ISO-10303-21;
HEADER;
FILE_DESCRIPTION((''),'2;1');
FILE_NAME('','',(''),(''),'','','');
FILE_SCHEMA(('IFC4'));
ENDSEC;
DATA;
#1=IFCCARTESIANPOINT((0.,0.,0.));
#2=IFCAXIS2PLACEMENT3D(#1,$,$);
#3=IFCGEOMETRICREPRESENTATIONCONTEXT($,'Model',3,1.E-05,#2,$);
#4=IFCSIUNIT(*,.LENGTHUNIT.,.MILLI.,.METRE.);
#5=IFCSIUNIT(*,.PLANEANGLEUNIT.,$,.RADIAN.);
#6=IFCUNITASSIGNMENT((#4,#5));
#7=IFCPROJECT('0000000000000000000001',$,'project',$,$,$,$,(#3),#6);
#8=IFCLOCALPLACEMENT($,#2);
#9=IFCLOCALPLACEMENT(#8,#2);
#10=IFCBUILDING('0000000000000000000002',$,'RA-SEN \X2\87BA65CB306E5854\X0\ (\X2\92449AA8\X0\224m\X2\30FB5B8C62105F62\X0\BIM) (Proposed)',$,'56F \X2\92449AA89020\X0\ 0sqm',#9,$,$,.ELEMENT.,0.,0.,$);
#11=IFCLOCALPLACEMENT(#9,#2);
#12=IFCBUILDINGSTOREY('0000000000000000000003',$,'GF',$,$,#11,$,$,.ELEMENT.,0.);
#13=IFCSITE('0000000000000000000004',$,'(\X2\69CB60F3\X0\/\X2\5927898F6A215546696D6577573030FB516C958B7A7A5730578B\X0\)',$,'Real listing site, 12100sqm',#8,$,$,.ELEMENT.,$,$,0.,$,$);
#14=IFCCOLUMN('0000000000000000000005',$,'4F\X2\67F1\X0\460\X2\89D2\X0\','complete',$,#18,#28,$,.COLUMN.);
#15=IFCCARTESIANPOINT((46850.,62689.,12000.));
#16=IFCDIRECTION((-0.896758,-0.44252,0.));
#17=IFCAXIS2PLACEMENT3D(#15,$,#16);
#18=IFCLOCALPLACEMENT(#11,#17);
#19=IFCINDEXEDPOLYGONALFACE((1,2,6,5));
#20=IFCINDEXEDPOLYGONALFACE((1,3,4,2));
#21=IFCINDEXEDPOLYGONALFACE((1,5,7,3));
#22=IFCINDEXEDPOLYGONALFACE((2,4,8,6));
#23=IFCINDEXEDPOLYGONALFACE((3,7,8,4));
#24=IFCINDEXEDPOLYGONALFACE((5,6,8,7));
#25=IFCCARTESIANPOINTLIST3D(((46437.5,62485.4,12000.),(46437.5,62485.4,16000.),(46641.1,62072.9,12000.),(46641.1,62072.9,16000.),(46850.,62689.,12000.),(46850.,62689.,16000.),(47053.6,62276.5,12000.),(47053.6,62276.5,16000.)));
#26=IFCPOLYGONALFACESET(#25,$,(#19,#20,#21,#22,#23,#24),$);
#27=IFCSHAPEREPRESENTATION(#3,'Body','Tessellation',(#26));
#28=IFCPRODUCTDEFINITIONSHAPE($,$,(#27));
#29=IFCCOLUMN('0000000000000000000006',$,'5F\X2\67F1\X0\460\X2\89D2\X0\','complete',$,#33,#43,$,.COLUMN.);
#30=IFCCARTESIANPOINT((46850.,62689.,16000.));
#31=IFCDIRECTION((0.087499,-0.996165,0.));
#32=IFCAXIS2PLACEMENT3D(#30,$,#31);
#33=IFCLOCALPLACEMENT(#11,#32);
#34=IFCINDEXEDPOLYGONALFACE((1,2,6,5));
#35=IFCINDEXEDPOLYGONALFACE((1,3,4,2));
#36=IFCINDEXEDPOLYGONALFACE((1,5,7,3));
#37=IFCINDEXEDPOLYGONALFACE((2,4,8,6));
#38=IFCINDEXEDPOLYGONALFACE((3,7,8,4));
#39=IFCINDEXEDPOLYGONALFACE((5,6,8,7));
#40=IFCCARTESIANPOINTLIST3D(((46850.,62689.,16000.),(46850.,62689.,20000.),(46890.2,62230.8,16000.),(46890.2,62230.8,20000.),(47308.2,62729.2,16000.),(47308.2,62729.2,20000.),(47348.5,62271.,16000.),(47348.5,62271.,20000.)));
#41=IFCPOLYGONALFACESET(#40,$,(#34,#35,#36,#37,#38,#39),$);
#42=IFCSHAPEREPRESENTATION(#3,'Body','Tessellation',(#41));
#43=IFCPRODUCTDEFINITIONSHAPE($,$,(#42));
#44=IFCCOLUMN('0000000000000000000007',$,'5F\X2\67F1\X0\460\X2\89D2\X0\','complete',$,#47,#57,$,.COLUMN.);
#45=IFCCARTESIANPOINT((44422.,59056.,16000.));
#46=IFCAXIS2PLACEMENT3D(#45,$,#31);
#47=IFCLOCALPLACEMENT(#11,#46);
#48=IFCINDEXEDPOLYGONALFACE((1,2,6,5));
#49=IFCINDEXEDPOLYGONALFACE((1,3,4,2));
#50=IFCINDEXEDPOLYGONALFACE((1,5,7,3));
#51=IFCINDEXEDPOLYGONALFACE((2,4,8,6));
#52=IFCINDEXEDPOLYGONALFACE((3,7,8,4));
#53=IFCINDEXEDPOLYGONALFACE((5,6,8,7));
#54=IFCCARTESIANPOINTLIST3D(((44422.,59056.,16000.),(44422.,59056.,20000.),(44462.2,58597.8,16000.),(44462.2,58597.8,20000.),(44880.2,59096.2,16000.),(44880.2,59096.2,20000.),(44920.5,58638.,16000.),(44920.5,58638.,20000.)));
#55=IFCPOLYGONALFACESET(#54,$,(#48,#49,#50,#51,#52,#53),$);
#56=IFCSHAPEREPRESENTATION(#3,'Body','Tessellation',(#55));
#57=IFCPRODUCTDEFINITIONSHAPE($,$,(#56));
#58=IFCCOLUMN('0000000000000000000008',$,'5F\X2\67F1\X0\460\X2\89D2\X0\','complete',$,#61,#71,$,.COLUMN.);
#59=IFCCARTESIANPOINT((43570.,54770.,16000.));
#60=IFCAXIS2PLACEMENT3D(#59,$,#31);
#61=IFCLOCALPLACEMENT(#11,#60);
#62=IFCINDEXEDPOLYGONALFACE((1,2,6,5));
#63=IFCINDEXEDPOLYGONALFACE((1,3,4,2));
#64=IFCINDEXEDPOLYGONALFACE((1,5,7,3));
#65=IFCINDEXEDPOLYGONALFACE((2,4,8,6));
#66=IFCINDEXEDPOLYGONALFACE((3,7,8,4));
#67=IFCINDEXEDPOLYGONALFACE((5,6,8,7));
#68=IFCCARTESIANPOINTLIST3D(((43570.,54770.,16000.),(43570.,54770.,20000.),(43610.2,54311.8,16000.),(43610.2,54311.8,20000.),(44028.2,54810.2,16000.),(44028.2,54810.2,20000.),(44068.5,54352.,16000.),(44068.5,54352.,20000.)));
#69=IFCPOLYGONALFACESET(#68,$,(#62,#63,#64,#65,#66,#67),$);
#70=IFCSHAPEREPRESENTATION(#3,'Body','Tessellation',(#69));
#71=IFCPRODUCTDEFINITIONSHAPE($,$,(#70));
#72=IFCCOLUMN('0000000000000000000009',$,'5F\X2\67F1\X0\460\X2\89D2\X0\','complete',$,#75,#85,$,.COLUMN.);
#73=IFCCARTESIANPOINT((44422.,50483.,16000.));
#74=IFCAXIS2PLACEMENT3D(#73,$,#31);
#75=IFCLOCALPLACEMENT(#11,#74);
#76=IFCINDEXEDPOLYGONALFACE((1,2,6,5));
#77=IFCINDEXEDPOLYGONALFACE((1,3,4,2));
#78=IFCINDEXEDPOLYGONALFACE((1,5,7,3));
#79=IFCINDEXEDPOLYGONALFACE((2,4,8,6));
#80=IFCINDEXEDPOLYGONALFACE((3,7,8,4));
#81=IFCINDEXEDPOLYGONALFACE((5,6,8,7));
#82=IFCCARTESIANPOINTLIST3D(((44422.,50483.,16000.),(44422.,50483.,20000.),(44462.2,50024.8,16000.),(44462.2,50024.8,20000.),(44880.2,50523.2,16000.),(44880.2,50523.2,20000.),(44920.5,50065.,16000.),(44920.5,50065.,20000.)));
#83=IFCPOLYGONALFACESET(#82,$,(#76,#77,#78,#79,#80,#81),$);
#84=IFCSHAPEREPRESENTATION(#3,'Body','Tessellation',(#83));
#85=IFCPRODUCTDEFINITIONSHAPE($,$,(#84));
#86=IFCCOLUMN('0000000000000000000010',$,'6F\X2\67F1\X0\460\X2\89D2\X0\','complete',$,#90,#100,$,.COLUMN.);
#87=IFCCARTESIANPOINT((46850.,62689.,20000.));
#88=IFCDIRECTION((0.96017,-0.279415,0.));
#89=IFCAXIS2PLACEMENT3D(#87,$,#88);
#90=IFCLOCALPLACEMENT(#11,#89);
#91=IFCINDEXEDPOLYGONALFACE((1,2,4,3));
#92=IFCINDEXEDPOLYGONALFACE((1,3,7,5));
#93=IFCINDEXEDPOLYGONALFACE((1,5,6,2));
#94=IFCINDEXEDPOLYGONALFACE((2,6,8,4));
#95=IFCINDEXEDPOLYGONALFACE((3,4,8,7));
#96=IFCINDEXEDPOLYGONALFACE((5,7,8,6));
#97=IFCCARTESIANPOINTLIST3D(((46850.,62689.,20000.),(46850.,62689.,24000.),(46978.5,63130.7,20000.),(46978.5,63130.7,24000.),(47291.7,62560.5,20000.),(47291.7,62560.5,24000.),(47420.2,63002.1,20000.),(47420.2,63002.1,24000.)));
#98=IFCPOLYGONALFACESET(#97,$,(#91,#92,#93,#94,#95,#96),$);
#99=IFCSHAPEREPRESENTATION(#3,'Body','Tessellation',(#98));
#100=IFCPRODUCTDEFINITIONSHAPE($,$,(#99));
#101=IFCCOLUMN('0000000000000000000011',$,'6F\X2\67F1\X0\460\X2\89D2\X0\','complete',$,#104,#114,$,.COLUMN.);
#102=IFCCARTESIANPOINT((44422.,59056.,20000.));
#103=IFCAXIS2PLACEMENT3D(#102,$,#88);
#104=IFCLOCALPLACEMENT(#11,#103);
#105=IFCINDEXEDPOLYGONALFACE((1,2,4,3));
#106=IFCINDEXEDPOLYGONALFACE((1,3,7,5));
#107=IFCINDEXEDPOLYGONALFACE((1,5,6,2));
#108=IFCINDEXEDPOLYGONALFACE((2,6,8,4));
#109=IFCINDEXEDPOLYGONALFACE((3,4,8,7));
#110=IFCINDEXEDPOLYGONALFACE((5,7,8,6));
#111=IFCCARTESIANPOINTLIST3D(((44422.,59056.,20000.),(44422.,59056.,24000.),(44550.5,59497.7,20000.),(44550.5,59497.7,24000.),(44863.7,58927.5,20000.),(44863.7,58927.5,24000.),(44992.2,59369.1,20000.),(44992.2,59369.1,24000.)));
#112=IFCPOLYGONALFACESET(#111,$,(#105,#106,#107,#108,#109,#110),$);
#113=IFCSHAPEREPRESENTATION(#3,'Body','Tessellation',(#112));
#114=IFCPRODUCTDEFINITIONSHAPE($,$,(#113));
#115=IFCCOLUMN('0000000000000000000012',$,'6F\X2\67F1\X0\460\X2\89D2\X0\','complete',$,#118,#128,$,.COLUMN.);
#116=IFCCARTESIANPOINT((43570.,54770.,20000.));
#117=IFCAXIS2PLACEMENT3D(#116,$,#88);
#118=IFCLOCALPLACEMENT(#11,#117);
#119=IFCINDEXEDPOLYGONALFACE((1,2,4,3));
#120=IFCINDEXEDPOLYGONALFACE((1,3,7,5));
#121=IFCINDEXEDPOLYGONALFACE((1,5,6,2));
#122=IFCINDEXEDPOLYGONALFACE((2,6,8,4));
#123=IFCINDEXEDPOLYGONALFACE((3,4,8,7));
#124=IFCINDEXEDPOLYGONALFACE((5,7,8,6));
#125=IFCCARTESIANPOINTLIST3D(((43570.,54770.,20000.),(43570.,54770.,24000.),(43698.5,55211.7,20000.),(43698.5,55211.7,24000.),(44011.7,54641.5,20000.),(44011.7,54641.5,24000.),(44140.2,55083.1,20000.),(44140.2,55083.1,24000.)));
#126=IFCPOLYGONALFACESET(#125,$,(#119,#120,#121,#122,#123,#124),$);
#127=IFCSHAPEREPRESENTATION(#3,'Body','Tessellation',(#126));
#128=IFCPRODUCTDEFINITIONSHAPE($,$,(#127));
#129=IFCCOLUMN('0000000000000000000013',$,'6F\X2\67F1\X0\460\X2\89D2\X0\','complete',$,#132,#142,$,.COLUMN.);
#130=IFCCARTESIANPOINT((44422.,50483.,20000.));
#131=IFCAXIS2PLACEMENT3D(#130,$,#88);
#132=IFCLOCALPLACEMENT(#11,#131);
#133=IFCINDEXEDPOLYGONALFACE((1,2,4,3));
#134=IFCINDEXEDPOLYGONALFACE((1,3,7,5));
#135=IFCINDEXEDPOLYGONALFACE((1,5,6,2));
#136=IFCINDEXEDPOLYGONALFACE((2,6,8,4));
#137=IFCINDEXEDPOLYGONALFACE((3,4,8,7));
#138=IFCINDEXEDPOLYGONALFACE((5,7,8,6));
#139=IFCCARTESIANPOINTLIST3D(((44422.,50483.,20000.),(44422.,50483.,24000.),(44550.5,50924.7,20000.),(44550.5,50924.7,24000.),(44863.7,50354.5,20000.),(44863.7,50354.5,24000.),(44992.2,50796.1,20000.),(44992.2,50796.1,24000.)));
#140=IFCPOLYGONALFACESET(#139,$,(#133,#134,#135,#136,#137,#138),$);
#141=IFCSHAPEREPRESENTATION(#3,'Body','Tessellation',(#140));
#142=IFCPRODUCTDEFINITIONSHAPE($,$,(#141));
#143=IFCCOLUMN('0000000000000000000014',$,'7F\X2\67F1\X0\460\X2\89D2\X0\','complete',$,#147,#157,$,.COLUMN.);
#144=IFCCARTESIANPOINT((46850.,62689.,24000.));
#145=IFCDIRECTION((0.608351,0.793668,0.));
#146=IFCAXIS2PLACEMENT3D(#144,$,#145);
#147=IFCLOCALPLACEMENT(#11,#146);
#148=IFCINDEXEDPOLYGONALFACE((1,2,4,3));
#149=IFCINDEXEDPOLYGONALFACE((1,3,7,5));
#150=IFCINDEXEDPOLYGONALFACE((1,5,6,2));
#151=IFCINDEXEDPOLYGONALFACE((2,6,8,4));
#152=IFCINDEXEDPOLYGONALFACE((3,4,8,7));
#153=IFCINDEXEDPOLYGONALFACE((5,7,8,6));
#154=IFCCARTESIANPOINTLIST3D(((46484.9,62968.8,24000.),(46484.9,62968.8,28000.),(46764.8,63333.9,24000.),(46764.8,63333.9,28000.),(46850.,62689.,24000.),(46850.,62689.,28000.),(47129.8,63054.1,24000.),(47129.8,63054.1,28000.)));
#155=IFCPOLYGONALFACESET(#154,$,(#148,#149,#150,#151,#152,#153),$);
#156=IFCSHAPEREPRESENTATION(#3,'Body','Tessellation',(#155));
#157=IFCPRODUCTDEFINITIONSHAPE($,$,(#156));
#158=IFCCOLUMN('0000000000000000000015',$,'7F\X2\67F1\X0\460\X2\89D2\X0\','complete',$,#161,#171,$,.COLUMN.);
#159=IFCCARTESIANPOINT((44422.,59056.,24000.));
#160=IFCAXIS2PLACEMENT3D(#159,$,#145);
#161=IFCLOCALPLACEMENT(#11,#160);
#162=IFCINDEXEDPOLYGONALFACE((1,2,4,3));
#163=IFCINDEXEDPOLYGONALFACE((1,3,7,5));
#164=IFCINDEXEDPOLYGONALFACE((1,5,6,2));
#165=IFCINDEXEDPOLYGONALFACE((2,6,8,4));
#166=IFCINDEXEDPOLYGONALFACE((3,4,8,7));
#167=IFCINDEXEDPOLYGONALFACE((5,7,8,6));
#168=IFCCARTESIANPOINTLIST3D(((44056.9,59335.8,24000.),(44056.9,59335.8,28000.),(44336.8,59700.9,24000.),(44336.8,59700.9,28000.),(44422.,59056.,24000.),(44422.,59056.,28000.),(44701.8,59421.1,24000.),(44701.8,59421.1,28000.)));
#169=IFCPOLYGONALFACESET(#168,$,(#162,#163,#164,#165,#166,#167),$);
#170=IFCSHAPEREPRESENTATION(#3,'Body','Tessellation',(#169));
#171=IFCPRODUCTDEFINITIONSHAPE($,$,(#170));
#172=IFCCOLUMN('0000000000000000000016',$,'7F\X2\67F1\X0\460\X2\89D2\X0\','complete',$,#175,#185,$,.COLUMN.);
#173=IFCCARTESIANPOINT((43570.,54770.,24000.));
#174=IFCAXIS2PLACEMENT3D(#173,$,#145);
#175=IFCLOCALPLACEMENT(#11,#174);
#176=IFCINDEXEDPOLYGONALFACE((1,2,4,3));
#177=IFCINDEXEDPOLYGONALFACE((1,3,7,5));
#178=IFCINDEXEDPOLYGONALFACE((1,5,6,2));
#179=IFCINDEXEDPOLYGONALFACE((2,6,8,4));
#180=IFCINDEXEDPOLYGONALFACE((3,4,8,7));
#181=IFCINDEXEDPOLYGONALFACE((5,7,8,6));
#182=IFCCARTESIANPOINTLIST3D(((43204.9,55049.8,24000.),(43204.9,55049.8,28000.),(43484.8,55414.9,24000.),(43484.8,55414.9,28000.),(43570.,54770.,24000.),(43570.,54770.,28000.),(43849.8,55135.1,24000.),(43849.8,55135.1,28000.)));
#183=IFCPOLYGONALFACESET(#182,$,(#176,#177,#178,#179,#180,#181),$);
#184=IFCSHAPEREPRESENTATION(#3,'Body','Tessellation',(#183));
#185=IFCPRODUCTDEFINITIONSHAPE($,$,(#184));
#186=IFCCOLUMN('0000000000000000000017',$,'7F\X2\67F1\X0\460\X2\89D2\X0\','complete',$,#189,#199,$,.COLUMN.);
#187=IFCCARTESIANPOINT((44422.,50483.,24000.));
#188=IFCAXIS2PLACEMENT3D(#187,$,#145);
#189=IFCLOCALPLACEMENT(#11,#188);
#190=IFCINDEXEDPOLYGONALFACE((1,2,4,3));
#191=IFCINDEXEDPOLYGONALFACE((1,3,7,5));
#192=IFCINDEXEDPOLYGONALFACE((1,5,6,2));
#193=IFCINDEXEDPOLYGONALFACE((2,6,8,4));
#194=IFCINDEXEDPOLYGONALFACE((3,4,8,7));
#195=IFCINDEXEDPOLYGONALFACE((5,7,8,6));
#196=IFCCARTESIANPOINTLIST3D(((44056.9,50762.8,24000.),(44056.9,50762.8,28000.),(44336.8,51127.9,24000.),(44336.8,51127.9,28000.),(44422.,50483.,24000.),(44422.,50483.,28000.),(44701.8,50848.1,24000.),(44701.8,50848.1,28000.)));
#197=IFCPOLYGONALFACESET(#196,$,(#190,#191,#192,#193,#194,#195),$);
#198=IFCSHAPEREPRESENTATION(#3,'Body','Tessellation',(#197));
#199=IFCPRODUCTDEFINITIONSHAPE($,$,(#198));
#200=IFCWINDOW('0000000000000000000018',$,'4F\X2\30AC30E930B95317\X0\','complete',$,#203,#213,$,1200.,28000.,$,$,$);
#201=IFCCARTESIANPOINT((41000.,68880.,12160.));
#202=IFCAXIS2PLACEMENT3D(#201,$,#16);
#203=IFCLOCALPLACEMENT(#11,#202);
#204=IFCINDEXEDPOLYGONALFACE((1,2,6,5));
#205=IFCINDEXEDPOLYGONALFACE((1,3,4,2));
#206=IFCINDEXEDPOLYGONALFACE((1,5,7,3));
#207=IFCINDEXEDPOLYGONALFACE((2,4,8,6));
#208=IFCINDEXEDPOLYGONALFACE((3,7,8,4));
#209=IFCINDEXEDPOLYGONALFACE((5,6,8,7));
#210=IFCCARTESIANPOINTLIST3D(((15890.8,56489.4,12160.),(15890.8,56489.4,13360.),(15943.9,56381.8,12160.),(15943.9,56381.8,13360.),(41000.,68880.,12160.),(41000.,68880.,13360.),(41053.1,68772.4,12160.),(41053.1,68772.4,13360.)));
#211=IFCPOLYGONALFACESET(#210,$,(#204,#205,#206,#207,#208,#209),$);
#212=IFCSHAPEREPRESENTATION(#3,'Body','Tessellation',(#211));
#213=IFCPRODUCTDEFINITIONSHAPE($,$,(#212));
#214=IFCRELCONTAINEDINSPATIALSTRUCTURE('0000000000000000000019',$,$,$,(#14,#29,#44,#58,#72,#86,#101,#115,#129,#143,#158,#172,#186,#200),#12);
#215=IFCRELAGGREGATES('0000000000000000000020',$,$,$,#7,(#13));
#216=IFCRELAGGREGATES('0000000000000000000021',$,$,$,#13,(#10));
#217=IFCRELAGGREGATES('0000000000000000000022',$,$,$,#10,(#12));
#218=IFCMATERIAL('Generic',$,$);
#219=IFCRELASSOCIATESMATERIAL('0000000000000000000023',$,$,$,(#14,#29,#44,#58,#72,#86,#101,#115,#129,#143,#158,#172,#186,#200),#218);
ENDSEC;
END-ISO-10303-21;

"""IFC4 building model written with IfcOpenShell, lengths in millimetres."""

from ifc_helpers import new_model, si_unit, frame, frame_2d, origin, place, context, project, spatial, rectangle, extrude, material, element, save


model = new_model("IFC4")

# Units and contexts
model_context = context("Model", 3, precision=1e-05, world=origin())
ifc_project = project(units=[si_unit("LENGTHUNIT", "METRE", prefix="MILLI"), si_unit("PLANEANGLEUNIT", "RADIAN")], contexts=[model_context])

# Site, building, storey
site_placement = place(None, origin())
site = spatial("IfcSite", under=ifc_project, at=site_placement, Name="(構想/大規模商業敷地・公開空地型)", ObjectType="Real listing site, 12100sqm", CompositionType="ELEMENT", RefElevation=0.0)
building_placement = place(site_placement, origin())
building = spatial("IfcBuilding", under=site, at=building_placement, Name="RA-SEN 螺旋の塔 (鉄骨224m・完成形BIM) (Proposed)", ObjectType="56F 鉄骨造 0sqm", CompositionType="ELEMENT", ElevationOfRefHeight=0.0, ElevationOfTerrain=0.0)
storey_placement = place(building_placement, origin())
storey = spatial("IfcBuildingStorey", under=building, at=storey_placement, Name="GF", CompositionType="ELEMENT", Elevation=0.0)

# Columns
ifc_material = material(Name="Generic")
column_1_placement = place(storey_placement, frame((46850.0, 62689.0, 12000.0), x_axis=(-0.896758, -0.44252, 0.0)))
element("IfcColumn", 1, at=column_1_placement, inside=storey, material=ifc_material, Name="4F柱460角", Description="complete", PredefinedType="COLUMN", context=model_context, shape_type="SweptSolid", body=[
    extrude(rectangle(XDim=460.0, YDim=460.0, at=frame_2d((230.0, 230.0))), frame((46850.0, 62689.0, 12000.0), x_axis=(-0.896758, -0.44252, 0.0)), (0.0, 0.0, 1.0), 4000.0),
])
column_2_placement = place(storey_placement, frame((46850.0, 62689.0, 16000.0), x_axis=(0.087499, -0.996165, 0.0)))
element("IfcColumn", 2, at=column_2_placement, inside=storey, material=ifc_material, Name="5F柱460角", Description="complete", PredefinedType="COLUMN", context=model_context, shape_type="SweptSolid", body=[
    extrude(rectangle(XDim=460.0, YDim=460.0, at=frame_2d((230.0, 230.0))), frame((46850.0, 62689.0, 16000.0), x_axis=(0.087499, -0.996165, 0.0)), (0.0, 0.0, 1.0), 4000.0),
])
column_3_placement = place(storey_placement, frame((44422.0, 59056.0, 16000.0), x_axis=(0.087499, -0.996165, 0.0)))
element("IfcColumn", 3, at=column_3_placement, inside=storey, material=ifc_material, Name="5F柱460角", Description="complete", PredefinedType="COLUMN", context=model_context, shape_type="SweptSolid", body=[
    extrude(rectangle(XDim=460.0, YDim=460.0, at=frame_2d((230.0, 230.0))), frame((44422.0, 59056.0, 16000.0), x_axis=(0.087499, -0.996165, 0.0)), (0.0, 0.0, 1.0), 4000.0),
])
column_4_placement = place(storey_placement, frame((43570.0, 54770.0, 16000.0), x_axis=(0.087499, -0.996165, 0.0)))
element("IfcColumn", 4, at=column_4_placement, inside=storey, material=ifc_material, Name="5F柱460角", Description="complete", PredefinedType="COLUMN", context=model_context, shape_type="SweptSolid", body=[
    extrude(rectangle(XDim=460.0, YDim=460.0, at=frame_2d((230.0, 230.0))), frame((43570.0, 54770.0, 16000.0), x_axis=(0.087499, -0.996165, 0.0)), (0.0, 0.0, 1.0), 4000.0),
])
column_5_placement = place(storey_placement, frame((44422.0, 50483.0, 16000.0), x_axis=(0.087499, -0.996165, 0.0)))
element("IfcColumn", 5, at=column_5_placement, inside=storey, material=ifc_material, Name="5F柱460角", Description="complete", PredefinedType="COLUMN", context=model_context, shape_type="SweptSolid", body=[
    extrude(rectangle(XDim=460.0, YDim=460.0, at=frame_2d((230.0, 230.0))), frame((44422.0, 50483.0, 16000.0), x_axis=(0.087499, -0.996165, 0.0)), (0.0, 0.0, 1.0), 4000.0),
])
column_6_placement = place(storey_placement, frame((46850.0, 62689.0, 20000.0), x_axis=(0.96017, -0.279415, 0.0)))
element("IfcColumn", 6, at=column_6_placement, inside=storey, material=ifc_material, Name="6F柱460角", Description="complete", PredefinedType="COLUMN", context=model_context, shape_type="SweptSolid", body=[
    extrude(rectangle(XDim=460.0, YDim=460.0, at=frame_2d((230.0, 230.0))), frame((46850.0, 62689.0, 20000.0), x_axis=(0.96017, -0.279415, 0.0)), (0.0, 0.0, 1.0), 4000.0),
])
column_7_placement = place(storey_placement, frame((44422.0, 59056.0, 20000.0), x_axis=(0.96017, -0.279415, 0.0)))
element("IfcColumn", 7, at=column_7_placement, inside=storey, material=ifc_material, Name="6F柱460角", Description="complete", PredefinedType="COLUMN", context=model_context, shape_type="SweptSolid", body=[
    extrude(rectangle(XDim=460.0, YDim=460.0, at=frame_2d((230.0, 230.0))), frame((44422.0, 59056.0, 20000.0), x_axis=(0.96017, -0.279415, 0.0)), (0.0, 0.0, 1.0), 4000.0),
])
column_8_placement = place(storey_placement, frame((43570.0, 54770.0, 20000.0), x_axis=(0.96017, -0.279415, 0.0)))
element("IfcColumn", 8, at=column_8_placement, inside=storey, material=ifc_material, Name="6F柱460角", Description="complete", PredefinedType="COLUMN", context=model_context, shape_type="SweptSolid", body=[
    extrude(rectangle(XDim=460.0, YDim=460.0, at=frame_2d((230.0, 230.0))), frame((43570.0, 54770.0, 20000.0), x_axis=(0.96017, -0.279415, 0.0)), (0.0, 0.0, 1.0), 4000.0),
])
column_9_placement = place(storey_placement, frame((44422.0, 50483.0, 20000.0), x_axis=(0.96017, -0.279415, 0.0)))
element("IfcColumn", 9, at=column_9_placement, inside=storey, material=ifc_material, Name="6F柱460角", Description="complete", PredefinedType="COLUMN", context=model_context, shape_type="SweptSolid", body=[
    extrude(rectangle(XDim=460.0, YDim=460.0, at=frame_2d((230.0, 230.0))), frame((44422.0, 50483.0, 20000.0), x_axis=(0.96017, -0.279415, 0.0)), (0.0, 0.0, 1.0), 4000.0),
])
column_10_placement = place(storey_placement, frame((46850.0, 62689.0, 24000.0), x_axis=(0.608351, 0.793668, 0.0)))
element("IfcColumn", 10, at=column_10_placement, inside=storey, material=ifc_material, Name="7F柱460角", Description="complete", PredefinedType="COLUMN", context=model_context, shape_type="SweptSolid", body=[
    extrude(rectangle(XDim=460.0, YDim=460.0, at=frame_2d((230.0, 230.0))), frame((46850.0, 62689.0, 24000.0), x_axis=(0.608351, 0.793668, 0.0)), (0.0, 0.0, 1.0), 4000.0),
])
column_11_placement = place(storey_placement, frame((44422.0, 59056.0, 24000.0), x_axis=(0.608351, 0.793668, 0.0)))
element("IfcColumn", 11, at=column_11_placement, inside=storey, material=ifc_material, Name="7F柱460角", Description="complete", PredefinedType="COLUMN", context=model_context, shape_type="SweptSolid", body=[
    extrude(rectangle(XDim=460.0, YDim=460.0, at=frame_2d((230.0, 230.0))), frame((44422.0, 59056.0, 24000.0), x_axis=(0.608351, 0.793668, 0.0)), (0.0, 0.0, 1.0), 4000.0),
])
column_12_placement = place(storey_placement, frame((43570.0, 54770.0, 24000.0), x_axis=(0.608351, 0.793668, 0.0)))
element("IfcColumn", 12, at=column_12_placement, inside=storey, material=ifc_material, Name="7F柱460角", Description="complete", PredefinedType="COLUMN", context=model_context, shape_type="SweptSolid", body=[
    extrude(rectangle(XDim=460.0, YDim=460.0, at=frame_2d((230.0, 230.0))), frame((43570.0, 54770.0, 24000.0), x_axis=(0.608351, 0.793668, 0.0)), (0.0, 0.0, 1.0), 4000.0),
])
column_13_placement = place(storey_placement, frame((44422.0, 50483.0, 24000.0), x_axis=(0.608351, 0.793668, 0.0)))
element("IfcColumn", 13, at=column_13_placement, inside=storey, material=ifc_material, Name="7F柱460角", Description="complete", PredefinedType="COLUMN", context=model_context, shape_type="SweptSolid", body=[
    extrude(rectangle(XDim=460.0, YDim=460.0, at=frame_2d((230.0, 230.0))), frame((44422.0, 50483.0, 24000.0), x_axis=(0.608351, 0.793668, 0.0)), (0.0, 0.0, 1.0), 4000.0),
])

# Window
window_1_placement = place(storey_placement, frame((41000.0, 68880.0, 12160.0), x_axis=(-0.896758, -0.44252, 0.0)))
element("IfcWindow", 14, at=window_1_placement, inside=storey, material=ifc_material, Name="4Fガラス北", Description="complete", OverallHeight=1200.0, OverallWidth=28000.0, context=model_context, shape_type="SweptSolid", body=[
    extrude(rectangle(XDim=28000.0, YDim=120.0, at=frame_2d((14000.0, 60.0))), frame((41000.0, 68880.0, 12160.0), x_axis=(-0.896758, -0.44252, 0.0)), (0.0, 0.0, 1.0), 1200.0),
])

save(model, "model.ifc")
